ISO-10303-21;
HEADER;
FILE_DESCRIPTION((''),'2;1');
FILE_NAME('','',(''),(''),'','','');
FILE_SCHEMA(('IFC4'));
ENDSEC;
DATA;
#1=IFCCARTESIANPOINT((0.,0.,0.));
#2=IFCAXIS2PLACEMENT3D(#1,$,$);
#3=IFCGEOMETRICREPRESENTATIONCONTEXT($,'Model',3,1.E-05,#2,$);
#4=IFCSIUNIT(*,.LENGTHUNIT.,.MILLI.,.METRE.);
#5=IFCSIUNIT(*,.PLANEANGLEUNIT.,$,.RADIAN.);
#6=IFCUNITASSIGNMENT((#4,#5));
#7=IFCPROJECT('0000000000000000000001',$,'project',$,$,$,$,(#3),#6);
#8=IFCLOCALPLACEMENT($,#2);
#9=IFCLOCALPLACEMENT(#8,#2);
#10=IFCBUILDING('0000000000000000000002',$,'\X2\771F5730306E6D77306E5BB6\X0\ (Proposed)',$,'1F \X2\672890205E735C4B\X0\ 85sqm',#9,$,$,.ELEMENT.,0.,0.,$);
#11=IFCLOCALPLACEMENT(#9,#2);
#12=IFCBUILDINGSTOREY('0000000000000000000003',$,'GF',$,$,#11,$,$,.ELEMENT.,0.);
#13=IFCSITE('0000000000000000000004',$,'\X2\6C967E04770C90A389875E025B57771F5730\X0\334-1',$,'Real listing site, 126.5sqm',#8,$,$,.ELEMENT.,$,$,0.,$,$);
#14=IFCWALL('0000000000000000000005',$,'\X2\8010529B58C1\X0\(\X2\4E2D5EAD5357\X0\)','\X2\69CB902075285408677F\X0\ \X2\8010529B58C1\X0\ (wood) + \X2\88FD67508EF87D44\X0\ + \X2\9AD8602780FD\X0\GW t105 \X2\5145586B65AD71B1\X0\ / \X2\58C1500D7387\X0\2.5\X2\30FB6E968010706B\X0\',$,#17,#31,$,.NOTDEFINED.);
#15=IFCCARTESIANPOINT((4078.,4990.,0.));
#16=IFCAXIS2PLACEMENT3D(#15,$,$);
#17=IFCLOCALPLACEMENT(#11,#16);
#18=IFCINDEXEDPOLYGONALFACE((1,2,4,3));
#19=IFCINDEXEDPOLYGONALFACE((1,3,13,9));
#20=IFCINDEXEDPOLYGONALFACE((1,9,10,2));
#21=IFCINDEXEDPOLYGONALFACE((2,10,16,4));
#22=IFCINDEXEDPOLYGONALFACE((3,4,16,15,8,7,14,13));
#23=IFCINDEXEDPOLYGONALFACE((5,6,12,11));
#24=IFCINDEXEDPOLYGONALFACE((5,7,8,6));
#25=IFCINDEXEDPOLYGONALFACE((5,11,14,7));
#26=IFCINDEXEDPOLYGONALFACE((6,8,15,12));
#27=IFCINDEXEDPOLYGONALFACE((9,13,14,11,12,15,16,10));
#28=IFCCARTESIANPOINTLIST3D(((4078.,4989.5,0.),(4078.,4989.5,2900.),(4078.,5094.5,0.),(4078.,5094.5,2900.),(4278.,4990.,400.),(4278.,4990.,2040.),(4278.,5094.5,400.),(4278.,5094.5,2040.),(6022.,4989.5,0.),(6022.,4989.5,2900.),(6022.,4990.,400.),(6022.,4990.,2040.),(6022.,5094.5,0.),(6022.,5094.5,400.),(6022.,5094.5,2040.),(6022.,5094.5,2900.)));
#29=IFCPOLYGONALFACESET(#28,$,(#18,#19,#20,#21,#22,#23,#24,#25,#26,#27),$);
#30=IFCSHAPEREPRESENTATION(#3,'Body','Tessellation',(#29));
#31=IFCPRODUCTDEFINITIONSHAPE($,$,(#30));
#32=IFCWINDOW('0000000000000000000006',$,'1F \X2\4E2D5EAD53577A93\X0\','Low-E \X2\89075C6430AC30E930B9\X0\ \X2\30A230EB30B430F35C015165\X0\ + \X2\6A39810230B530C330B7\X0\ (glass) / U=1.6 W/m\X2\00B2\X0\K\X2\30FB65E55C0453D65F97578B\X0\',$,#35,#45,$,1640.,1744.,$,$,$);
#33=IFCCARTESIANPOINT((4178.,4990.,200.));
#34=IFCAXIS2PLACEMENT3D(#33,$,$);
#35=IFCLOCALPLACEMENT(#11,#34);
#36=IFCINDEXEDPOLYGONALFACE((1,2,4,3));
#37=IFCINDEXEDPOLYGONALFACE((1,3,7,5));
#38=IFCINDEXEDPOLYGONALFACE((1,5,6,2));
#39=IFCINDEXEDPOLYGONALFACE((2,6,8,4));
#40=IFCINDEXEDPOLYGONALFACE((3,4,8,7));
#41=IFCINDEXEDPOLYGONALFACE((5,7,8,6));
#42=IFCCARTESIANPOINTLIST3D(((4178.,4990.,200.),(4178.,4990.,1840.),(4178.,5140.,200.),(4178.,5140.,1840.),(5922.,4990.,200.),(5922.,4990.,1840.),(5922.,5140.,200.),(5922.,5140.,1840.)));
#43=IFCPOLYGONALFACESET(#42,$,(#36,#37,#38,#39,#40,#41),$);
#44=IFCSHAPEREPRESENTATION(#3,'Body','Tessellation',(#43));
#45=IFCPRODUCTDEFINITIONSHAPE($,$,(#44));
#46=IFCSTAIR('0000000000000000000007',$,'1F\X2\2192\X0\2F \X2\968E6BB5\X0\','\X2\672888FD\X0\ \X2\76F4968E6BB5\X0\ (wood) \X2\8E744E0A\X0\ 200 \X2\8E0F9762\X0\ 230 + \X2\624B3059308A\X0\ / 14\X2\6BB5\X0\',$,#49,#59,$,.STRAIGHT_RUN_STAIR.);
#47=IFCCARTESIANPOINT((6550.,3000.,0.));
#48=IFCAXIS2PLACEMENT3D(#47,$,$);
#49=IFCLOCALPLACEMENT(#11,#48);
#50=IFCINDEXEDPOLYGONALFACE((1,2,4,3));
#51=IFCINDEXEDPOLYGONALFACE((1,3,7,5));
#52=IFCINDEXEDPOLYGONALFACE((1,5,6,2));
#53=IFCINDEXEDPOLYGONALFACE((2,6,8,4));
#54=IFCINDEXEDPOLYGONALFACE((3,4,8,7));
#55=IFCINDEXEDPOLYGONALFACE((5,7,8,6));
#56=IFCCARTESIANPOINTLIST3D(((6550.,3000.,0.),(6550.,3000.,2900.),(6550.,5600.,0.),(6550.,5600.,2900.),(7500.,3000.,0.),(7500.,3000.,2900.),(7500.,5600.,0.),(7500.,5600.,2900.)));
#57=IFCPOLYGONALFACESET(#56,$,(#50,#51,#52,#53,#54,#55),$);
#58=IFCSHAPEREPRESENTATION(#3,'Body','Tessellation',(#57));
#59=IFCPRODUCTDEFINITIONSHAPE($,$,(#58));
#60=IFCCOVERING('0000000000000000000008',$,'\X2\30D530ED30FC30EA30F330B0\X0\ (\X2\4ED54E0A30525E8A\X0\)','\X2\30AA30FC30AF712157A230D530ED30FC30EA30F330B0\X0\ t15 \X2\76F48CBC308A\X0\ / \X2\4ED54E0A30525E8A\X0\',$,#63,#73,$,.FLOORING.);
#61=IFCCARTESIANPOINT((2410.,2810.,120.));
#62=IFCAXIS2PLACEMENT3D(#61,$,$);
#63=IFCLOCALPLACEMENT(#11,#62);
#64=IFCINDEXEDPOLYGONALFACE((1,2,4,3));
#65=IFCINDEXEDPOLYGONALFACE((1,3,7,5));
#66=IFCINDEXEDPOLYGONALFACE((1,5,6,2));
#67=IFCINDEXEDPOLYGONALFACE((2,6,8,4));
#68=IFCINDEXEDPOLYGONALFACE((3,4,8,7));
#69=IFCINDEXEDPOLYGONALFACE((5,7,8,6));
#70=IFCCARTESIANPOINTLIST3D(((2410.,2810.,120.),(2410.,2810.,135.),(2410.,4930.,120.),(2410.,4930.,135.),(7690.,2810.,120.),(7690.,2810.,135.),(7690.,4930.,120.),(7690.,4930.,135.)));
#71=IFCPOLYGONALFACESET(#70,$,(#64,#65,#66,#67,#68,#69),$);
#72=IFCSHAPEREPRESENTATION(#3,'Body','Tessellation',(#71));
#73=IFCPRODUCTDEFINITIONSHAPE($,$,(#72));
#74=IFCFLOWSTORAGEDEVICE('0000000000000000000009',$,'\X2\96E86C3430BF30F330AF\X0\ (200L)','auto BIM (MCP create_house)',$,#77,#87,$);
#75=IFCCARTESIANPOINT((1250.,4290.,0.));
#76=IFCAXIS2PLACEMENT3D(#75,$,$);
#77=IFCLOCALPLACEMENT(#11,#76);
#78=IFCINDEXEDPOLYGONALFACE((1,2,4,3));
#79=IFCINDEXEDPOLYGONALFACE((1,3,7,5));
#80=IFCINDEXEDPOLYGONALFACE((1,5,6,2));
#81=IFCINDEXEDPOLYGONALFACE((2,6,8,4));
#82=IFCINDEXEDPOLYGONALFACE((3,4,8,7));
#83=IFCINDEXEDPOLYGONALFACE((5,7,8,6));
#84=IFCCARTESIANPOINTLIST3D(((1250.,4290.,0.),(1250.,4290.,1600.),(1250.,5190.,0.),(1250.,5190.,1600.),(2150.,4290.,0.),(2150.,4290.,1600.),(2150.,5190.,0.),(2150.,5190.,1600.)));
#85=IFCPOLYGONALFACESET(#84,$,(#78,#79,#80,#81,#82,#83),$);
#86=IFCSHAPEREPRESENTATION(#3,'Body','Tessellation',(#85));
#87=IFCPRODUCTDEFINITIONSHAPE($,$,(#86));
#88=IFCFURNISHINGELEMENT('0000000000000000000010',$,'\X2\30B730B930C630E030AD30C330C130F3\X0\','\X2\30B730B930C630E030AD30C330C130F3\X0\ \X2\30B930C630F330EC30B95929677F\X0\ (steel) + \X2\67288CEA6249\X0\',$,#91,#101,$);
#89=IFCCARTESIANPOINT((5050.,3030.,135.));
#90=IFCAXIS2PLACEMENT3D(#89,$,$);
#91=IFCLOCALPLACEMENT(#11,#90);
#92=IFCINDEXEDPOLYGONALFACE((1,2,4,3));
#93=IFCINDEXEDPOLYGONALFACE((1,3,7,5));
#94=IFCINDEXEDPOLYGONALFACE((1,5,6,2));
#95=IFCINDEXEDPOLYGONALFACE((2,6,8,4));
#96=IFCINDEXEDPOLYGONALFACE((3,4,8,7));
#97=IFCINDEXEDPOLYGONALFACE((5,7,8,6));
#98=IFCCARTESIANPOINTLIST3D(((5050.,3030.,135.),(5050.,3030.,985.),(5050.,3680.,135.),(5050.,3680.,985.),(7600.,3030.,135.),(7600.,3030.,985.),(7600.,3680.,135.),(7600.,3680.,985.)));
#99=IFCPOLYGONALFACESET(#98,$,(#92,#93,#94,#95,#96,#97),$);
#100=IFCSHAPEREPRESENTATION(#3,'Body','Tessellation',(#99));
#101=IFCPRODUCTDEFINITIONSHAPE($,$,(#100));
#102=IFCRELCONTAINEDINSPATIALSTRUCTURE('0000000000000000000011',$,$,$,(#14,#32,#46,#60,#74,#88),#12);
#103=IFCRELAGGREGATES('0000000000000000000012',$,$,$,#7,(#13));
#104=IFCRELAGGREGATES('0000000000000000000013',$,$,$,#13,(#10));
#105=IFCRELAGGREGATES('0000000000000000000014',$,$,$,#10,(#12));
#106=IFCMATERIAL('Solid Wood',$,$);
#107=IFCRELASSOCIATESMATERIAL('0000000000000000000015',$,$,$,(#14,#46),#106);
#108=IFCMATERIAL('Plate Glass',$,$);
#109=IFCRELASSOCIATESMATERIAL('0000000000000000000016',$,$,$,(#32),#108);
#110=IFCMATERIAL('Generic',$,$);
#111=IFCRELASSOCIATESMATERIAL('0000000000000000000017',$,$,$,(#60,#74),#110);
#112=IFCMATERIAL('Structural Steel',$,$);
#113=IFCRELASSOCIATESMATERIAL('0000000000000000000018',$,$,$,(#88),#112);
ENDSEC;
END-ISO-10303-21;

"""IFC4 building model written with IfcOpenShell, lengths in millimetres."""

from ifc_helpers import new_model, si_unit, frame, frame_2d, origin, place, context, project, spatial, rectangle, extrude, material, element, fill, save


model = new_model("IFC4")

# Units and contexts
model_context = context("Model", 3, precision=1e-05, world=origin())
ifc_project = project(units=[si_unit("LENGTHUNIT", "METRE", prefix="MILLI"), si_unit("PLANEANGLEUNIT", "RADIAN")], contexts=[model_context])

# Site, building, storey
site_placement = place(None, origin())
site = spatial("IfcSite", under=ifc_project, at=site_placement, Name="沖縄県那覇市字真地334-1", ObjectType="Real listing site, 126.5sqm", CompositionType="ELEMENT", RefElevation=0.0)
building_placement = place(site_placement, origin())
building = spatial("IfcBuilding", under=site, at=building_placement, Name="真地の海の家 (Proposed)", ObjectType="1F 木造平屋 85sqm", CompositionType="ELEMENT", ElevationOfRefHeight=0.0, ElevationOfTerrain=0.0)
storey_placement = place(building_placement, origin())
storey = spatial("IfcBuildingStorey", under=building, at=storey_placement, Name="GF", CompositionType="ELEMENT", Elevation=0.0)

# Shared definitions
ifc_material_1 = material(Name="Solid Wood")
ifc_material_2 = material(Name="Generic")

# Shared definitions
ifc_material_3 = material(Name="Plate Glass")

# Wall, opening, window
wall_1_placement = place(storey_placement, frame((4078.0, 4990.0, 0.0)))
wall_1 = element("IfcWall", 1, at=wall_1_placement, inside=storey, material=ifc_material_1, Name="耐力壁(中庭南)", Description="構造用合板 耐力壁 (wood) + 製材軸組 + 高性能GW t105 充填断熱 / 壁倍率2.5・準耐火", PredefinedType="NOTDEFINED", context=model_context, shape_type="SweptSolid", body=[
    extrude(rectangle(XDim=1944.0, YDim=105.0, at=frame_2d((972.0, 52.0))), frame((4078.0, 4990.0, 0.0)), (0.0, 0.0, 1.0), 2900.0),
])
opening_1_placement = place(storey_placement, frame((4178.0, 4990.0, 200.0)))
opening_1 = element("IfcOpeningElement", 2, at=opening_1_placement, cuts=wall_1, PredefinedType="NOTDEFINED", context=model_context, shape_type="SweptSolid", body=[
    extrude(rectangle(XDim=1744.0, YDim=150.0, at=frame_2d((872.0, 75.0))), frame((4178.0, 4990.0, 200.0)), (0.0, 0.0, 1.0), 1640.0),
])
window_1_placement = place(storey_placement, frame((4178.0, 4990.0, 200.0)))
window_1 = element("IfcWindow", 3, at=window_1_placement, inside=storey, material=ifc_material_3, Name="1F 中庭南窓", Description="Low-E 複層ガラス アルゴン封入 + 樹脂サッシ (glass) / U=1.6 W/m²K・日射取得型", OverallHeight=1640.0, OverallWidth=1744.0, context=model_context, shape_type="SweptSolid", body=[
    extrude(rectangle(XDim=1744.0, YDim=150.0, at=frame_2d((872.0, 75.0))), frame((4178.0, 4990.0, 200.0)), (0.0, 0.0, 1.0), 1640.0),
])
fill(opening_1, window_1)

# Stair
stair_placement = place(storey_placement, frame((6550.0, 3000.0, 0.0)))
element("IfcStair", 4, at=stair_placement, inside=storey, material=ifc_material_1, Name="1F→2F 階段", Description="木製 直階段 (wood) 蹴上 200 踏面 230 + 手すり / 14段", PredefinedType="STRAIGHT_RUN_STAIR", context=model_context, shape_type="SweptSolid", body=[
    extrude(rectangle(XDim=950.0, YDim=2600.0, at=frame_2d((475.0, 1300.0))), frame((6550.0, 3000.0, 0.0)), (0.0, 0.0, 1.0), 2900.0),
])

# Covering
covering_placement = place(storey_placement, frame((2410.0, 2810.0, 120.0)))
element("IfcCovering", 5, at=covering_placement, inside=storey, material=ifc_material_2, Name="フローリング (仕上げ床)", Description="オーク無垢フローリング t15 直貼り / 仕上げ床", PredefinedType="FLOORING", context=model_context, shape_type="SweptSolid", body=[
    extrude(rectangle(XDim=5280.0, YDim=2120.0, at=frame_2d((2640.0, 1060.0))), frame((2410.0, 2810.0, 120.0)), (0.0, 0.0, 1.0), 15.0),
])

# Flow storage device
flow_storage_device_placement = place(storey_placement, frame((1250.0, 4290.0, 0.0)))
element("IfcFlowStorageDevice", 6, at=flow_storage_device_placement, inside=storey, material=ifc_material_2, Name="雨水タンク (200L)", Description="auto BIM (MCP create_house)", context=model_context, shape_type="SweptSolid", body=[
    extrude(rectangle(XDim=900.0, YDim=900.0, at=frame_2d((450.0, 450.0))), frame((1250.0, 4290.0, 0.0)), (0.0, 0.0, 1.0), 1600.0),
])

# Furnishing element
ifc_material_4 = material(Name="Structural Steel")
furnishing_placement = place(storey_placement, frame((5050.0, 3030.0, 135.0)))
element("IfcFurnishingElement", 7, at=furnishing_placement, inside=storey, material=ifc_material_4, Name="システムキッチン", Description="システムキッチン ステンレス天板 (steel) + 木質扉", context=model_context, shape_type="SweptSolid", body=[
    extrude(rectangle(XDim=2550.0, YDim=650.0, at=frame_2d((1275.0, 325.0))), frame((5050.0, 3030.0, 135.0)), (0.0, 0.0, 1.0), 850.0),
])

save(model, "model.ifc")
